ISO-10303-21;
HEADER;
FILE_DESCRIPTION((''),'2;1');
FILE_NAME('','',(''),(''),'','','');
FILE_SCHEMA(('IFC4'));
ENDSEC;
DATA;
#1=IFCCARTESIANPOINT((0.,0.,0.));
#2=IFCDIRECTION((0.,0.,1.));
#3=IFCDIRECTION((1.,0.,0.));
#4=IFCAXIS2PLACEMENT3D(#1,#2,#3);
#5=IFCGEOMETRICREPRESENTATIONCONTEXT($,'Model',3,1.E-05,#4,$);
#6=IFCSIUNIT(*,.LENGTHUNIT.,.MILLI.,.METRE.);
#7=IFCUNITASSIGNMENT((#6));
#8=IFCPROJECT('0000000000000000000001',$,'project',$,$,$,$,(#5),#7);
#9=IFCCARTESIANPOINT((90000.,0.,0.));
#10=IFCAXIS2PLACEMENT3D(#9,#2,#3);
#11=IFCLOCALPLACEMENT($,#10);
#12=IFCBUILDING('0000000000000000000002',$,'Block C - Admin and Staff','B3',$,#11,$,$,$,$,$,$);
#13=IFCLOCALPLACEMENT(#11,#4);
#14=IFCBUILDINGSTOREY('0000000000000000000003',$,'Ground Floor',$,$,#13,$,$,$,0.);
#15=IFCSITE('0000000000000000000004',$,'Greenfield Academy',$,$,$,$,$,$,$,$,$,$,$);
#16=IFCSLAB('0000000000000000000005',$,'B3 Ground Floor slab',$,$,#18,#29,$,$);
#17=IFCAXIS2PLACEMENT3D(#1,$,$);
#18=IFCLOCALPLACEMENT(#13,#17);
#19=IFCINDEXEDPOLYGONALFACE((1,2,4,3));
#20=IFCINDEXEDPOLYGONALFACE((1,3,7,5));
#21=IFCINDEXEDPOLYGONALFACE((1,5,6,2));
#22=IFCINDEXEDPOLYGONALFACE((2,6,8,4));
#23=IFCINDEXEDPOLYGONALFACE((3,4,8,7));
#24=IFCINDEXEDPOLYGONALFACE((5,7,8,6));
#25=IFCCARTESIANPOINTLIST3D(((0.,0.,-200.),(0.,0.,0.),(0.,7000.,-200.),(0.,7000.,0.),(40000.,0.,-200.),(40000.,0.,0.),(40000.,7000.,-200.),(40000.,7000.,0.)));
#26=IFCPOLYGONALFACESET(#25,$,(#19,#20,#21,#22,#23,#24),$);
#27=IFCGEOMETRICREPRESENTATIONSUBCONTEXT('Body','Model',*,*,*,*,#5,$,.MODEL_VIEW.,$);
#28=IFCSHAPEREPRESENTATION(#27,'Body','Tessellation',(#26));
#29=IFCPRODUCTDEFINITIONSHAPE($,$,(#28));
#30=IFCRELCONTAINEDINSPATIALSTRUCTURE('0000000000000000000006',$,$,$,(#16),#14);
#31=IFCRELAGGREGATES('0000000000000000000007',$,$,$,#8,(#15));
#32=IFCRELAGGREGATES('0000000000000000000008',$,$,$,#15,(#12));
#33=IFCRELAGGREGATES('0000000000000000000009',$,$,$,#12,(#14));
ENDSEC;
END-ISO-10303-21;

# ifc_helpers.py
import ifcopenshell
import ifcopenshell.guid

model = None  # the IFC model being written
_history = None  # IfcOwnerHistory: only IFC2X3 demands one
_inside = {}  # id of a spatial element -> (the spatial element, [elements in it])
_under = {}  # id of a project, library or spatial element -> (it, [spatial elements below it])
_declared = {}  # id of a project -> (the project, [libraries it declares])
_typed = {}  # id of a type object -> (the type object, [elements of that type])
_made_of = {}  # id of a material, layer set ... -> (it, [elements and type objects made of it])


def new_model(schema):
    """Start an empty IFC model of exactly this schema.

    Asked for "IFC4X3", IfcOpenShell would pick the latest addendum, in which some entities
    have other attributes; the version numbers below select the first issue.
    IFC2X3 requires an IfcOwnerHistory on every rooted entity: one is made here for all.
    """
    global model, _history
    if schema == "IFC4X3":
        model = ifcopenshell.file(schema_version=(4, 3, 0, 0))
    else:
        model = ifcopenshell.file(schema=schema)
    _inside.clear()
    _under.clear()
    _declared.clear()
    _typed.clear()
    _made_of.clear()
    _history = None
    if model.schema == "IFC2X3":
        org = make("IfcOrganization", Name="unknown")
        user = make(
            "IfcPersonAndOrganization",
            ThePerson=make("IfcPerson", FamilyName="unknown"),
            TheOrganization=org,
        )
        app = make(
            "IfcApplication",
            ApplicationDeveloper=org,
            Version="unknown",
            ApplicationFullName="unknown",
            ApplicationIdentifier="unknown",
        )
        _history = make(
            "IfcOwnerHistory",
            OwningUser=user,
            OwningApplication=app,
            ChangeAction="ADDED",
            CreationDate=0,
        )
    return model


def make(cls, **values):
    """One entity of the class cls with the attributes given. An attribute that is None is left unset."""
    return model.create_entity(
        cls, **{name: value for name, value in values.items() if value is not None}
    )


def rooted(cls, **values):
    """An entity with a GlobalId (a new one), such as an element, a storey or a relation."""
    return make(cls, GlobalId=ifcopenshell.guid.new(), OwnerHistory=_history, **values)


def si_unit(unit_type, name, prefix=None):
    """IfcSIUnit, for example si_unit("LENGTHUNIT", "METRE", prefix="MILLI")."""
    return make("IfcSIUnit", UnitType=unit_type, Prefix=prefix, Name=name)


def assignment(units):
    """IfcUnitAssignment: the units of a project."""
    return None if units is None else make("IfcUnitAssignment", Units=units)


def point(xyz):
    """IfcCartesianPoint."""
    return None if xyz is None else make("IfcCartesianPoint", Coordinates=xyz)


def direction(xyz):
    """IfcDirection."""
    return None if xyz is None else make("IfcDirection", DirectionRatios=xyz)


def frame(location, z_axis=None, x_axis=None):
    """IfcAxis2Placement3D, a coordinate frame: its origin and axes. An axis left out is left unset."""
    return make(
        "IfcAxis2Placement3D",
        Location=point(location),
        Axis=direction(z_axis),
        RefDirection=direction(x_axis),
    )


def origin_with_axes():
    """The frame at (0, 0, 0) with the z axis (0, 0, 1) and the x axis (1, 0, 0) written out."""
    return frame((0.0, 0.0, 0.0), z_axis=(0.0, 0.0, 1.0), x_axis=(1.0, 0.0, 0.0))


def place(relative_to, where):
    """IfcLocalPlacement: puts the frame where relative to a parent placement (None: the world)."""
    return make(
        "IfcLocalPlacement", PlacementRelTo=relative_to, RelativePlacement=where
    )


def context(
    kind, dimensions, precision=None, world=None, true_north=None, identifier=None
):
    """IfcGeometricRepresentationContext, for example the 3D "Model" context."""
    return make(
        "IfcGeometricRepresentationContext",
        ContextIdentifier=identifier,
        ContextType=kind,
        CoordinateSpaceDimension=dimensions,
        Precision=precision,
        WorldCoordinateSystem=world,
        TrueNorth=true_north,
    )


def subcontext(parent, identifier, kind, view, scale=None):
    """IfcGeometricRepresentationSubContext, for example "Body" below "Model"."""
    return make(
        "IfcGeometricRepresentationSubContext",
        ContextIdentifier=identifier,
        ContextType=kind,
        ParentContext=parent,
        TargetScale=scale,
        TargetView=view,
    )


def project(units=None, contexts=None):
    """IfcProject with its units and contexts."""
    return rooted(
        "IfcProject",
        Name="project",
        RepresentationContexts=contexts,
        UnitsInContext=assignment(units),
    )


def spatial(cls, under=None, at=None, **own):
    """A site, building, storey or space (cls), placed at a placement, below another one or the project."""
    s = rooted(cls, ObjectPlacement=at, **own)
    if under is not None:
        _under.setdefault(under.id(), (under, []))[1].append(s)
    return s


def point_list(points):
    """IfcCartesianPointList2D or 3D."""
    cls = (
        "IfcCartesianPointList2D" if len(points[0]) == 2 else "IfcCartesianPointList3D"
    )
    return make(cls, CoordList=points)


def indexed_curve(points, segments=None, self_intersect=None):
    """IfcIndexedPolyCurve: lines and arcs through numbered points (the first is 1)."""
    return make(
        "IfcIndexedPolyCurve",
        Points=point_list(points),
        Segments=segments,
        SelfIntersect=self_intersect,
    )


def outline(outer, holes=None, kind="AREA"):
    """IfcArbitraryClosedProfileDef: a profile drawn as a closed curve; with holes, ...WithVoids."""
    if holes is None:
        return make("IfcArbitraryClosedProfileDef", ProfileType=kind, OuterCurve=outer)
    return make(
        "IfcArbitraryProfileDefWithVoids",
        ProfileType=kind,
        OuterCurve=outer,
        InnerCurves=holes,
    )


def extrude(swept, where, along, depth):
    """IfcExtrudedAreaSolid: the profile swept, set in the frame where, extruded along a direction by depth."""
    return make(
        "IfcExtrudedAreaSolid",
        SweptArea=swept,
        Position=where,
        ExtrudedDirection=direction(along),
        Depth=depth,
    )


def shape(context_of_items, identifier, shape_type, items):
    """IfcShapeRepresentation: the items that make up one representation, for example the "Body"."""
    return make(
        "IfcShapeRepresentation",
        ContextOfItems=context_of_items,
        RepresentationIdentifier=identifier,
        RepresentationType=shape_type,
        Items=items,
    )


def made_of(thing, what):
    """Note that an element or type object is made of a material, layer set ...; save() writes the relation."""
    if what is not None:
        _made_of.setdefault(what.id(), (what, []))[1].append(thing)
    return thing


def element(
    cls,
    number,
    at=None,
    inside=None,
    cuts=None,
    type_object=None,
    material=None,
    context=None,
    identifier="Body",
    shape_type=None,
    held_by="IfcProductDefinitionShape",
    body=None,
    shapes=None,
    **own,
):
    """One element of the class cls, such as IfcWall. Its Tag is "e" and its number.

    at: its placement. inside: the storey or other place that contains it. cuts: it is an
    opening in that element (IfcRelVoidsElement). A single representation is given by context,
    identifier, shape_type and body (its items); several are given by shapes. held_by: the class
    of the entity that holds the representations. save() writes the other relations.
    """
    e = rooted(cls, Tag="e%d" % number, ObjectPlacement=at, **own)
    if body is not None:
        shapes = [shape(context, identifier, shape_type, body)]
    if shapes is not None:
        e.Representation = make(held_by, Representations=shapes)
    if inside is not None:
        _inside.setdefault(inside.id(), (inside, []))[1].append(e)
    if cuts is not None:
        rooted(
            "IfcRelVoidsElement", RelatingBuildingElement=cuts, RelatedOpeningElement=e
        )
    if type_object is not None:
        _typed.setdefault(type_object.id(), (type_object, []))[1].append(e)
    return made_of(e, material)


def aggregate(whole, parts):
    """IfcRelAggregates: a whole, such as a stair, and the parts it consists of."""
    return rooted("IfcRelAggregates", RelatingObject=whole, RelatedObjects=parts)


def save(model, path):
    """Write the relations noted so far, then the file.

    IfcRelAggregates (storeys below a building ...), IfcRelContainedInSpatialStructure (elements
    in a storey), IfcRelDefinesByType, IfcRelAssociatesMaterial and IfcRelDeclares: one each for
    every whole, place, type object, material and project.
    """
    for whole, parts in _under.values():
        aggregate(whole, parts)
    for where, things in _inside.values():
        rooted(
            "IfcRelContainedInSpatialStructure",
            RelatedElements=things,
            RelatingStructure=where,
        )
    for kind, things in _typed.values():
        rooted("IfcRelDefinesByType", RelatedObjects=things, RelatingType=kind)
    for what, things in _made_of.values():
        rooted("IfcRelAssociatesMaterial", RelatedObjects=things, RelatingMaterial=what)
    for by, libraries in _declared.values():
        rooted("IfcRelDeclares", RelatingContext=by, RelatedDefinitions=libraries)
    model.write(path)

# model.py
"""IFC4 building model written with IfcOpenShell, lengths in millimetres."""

from ifc_helpers import new_model, si_unit, frame, origin_with_axes, place, context, subcontext, project, spatial, indexed_curve, outline, extrude, element, save


model = new_model("IFC4")

# Units and contexts
model_context = context("Model", 3, precision=1e-05, world=origin_with_axes())
body_context = subcontext(model_context, "Body", "Model", "MODEL_VIEW")
ifc_project = project(units=[si_unit("LENGTHUNIT", "METRE", prefix="MILLI")], contexts=[model_context])

# Site, building, storey
site = spatial("IfcSite", under=ifc_project, Name="Greenfield Academy")
building_placement = place(None, frame((90000.0, 0.0, 0.0), z_axis=(0.0, 0.0, 1.0), x_axis=(1.0, 0.0, 0.0)))
building = spatial("IfcBuilding", under=site, at=building_placement, Name="Block C - Admin and Staff", Description="B3")
storey_placement = place(building_placement, origin_with_axes())
storey = spatial("IfcBuildingStorey", under=building, at=storey_placement, Name="Ground Floor", Elevation=0.0)

# Slab
slab_placement = place(storey_placement, frame((0.0, 0.0, -200.0), z_axis=(0.0, 0.0, 1.0), x_axis=(1.0, 0.0, 0.0)))
element("IfcSlab", 1, at=slab_placement, inside=storey, Name="B3 Ground Floor slab", context=body_context, shape_type="SweptSolid", body=[
    extrude(outline(indexed_curve([(0.0, 0.0), (0.0, 7000.0), (40000.0, 7000.0), (40000.0, 0.0), (0.0, 0.0)], self_intersect=False)), origin_with_axes(), (0.0, 0.0, 1.0), 200.0),
])

save(model, "model.ifc")
